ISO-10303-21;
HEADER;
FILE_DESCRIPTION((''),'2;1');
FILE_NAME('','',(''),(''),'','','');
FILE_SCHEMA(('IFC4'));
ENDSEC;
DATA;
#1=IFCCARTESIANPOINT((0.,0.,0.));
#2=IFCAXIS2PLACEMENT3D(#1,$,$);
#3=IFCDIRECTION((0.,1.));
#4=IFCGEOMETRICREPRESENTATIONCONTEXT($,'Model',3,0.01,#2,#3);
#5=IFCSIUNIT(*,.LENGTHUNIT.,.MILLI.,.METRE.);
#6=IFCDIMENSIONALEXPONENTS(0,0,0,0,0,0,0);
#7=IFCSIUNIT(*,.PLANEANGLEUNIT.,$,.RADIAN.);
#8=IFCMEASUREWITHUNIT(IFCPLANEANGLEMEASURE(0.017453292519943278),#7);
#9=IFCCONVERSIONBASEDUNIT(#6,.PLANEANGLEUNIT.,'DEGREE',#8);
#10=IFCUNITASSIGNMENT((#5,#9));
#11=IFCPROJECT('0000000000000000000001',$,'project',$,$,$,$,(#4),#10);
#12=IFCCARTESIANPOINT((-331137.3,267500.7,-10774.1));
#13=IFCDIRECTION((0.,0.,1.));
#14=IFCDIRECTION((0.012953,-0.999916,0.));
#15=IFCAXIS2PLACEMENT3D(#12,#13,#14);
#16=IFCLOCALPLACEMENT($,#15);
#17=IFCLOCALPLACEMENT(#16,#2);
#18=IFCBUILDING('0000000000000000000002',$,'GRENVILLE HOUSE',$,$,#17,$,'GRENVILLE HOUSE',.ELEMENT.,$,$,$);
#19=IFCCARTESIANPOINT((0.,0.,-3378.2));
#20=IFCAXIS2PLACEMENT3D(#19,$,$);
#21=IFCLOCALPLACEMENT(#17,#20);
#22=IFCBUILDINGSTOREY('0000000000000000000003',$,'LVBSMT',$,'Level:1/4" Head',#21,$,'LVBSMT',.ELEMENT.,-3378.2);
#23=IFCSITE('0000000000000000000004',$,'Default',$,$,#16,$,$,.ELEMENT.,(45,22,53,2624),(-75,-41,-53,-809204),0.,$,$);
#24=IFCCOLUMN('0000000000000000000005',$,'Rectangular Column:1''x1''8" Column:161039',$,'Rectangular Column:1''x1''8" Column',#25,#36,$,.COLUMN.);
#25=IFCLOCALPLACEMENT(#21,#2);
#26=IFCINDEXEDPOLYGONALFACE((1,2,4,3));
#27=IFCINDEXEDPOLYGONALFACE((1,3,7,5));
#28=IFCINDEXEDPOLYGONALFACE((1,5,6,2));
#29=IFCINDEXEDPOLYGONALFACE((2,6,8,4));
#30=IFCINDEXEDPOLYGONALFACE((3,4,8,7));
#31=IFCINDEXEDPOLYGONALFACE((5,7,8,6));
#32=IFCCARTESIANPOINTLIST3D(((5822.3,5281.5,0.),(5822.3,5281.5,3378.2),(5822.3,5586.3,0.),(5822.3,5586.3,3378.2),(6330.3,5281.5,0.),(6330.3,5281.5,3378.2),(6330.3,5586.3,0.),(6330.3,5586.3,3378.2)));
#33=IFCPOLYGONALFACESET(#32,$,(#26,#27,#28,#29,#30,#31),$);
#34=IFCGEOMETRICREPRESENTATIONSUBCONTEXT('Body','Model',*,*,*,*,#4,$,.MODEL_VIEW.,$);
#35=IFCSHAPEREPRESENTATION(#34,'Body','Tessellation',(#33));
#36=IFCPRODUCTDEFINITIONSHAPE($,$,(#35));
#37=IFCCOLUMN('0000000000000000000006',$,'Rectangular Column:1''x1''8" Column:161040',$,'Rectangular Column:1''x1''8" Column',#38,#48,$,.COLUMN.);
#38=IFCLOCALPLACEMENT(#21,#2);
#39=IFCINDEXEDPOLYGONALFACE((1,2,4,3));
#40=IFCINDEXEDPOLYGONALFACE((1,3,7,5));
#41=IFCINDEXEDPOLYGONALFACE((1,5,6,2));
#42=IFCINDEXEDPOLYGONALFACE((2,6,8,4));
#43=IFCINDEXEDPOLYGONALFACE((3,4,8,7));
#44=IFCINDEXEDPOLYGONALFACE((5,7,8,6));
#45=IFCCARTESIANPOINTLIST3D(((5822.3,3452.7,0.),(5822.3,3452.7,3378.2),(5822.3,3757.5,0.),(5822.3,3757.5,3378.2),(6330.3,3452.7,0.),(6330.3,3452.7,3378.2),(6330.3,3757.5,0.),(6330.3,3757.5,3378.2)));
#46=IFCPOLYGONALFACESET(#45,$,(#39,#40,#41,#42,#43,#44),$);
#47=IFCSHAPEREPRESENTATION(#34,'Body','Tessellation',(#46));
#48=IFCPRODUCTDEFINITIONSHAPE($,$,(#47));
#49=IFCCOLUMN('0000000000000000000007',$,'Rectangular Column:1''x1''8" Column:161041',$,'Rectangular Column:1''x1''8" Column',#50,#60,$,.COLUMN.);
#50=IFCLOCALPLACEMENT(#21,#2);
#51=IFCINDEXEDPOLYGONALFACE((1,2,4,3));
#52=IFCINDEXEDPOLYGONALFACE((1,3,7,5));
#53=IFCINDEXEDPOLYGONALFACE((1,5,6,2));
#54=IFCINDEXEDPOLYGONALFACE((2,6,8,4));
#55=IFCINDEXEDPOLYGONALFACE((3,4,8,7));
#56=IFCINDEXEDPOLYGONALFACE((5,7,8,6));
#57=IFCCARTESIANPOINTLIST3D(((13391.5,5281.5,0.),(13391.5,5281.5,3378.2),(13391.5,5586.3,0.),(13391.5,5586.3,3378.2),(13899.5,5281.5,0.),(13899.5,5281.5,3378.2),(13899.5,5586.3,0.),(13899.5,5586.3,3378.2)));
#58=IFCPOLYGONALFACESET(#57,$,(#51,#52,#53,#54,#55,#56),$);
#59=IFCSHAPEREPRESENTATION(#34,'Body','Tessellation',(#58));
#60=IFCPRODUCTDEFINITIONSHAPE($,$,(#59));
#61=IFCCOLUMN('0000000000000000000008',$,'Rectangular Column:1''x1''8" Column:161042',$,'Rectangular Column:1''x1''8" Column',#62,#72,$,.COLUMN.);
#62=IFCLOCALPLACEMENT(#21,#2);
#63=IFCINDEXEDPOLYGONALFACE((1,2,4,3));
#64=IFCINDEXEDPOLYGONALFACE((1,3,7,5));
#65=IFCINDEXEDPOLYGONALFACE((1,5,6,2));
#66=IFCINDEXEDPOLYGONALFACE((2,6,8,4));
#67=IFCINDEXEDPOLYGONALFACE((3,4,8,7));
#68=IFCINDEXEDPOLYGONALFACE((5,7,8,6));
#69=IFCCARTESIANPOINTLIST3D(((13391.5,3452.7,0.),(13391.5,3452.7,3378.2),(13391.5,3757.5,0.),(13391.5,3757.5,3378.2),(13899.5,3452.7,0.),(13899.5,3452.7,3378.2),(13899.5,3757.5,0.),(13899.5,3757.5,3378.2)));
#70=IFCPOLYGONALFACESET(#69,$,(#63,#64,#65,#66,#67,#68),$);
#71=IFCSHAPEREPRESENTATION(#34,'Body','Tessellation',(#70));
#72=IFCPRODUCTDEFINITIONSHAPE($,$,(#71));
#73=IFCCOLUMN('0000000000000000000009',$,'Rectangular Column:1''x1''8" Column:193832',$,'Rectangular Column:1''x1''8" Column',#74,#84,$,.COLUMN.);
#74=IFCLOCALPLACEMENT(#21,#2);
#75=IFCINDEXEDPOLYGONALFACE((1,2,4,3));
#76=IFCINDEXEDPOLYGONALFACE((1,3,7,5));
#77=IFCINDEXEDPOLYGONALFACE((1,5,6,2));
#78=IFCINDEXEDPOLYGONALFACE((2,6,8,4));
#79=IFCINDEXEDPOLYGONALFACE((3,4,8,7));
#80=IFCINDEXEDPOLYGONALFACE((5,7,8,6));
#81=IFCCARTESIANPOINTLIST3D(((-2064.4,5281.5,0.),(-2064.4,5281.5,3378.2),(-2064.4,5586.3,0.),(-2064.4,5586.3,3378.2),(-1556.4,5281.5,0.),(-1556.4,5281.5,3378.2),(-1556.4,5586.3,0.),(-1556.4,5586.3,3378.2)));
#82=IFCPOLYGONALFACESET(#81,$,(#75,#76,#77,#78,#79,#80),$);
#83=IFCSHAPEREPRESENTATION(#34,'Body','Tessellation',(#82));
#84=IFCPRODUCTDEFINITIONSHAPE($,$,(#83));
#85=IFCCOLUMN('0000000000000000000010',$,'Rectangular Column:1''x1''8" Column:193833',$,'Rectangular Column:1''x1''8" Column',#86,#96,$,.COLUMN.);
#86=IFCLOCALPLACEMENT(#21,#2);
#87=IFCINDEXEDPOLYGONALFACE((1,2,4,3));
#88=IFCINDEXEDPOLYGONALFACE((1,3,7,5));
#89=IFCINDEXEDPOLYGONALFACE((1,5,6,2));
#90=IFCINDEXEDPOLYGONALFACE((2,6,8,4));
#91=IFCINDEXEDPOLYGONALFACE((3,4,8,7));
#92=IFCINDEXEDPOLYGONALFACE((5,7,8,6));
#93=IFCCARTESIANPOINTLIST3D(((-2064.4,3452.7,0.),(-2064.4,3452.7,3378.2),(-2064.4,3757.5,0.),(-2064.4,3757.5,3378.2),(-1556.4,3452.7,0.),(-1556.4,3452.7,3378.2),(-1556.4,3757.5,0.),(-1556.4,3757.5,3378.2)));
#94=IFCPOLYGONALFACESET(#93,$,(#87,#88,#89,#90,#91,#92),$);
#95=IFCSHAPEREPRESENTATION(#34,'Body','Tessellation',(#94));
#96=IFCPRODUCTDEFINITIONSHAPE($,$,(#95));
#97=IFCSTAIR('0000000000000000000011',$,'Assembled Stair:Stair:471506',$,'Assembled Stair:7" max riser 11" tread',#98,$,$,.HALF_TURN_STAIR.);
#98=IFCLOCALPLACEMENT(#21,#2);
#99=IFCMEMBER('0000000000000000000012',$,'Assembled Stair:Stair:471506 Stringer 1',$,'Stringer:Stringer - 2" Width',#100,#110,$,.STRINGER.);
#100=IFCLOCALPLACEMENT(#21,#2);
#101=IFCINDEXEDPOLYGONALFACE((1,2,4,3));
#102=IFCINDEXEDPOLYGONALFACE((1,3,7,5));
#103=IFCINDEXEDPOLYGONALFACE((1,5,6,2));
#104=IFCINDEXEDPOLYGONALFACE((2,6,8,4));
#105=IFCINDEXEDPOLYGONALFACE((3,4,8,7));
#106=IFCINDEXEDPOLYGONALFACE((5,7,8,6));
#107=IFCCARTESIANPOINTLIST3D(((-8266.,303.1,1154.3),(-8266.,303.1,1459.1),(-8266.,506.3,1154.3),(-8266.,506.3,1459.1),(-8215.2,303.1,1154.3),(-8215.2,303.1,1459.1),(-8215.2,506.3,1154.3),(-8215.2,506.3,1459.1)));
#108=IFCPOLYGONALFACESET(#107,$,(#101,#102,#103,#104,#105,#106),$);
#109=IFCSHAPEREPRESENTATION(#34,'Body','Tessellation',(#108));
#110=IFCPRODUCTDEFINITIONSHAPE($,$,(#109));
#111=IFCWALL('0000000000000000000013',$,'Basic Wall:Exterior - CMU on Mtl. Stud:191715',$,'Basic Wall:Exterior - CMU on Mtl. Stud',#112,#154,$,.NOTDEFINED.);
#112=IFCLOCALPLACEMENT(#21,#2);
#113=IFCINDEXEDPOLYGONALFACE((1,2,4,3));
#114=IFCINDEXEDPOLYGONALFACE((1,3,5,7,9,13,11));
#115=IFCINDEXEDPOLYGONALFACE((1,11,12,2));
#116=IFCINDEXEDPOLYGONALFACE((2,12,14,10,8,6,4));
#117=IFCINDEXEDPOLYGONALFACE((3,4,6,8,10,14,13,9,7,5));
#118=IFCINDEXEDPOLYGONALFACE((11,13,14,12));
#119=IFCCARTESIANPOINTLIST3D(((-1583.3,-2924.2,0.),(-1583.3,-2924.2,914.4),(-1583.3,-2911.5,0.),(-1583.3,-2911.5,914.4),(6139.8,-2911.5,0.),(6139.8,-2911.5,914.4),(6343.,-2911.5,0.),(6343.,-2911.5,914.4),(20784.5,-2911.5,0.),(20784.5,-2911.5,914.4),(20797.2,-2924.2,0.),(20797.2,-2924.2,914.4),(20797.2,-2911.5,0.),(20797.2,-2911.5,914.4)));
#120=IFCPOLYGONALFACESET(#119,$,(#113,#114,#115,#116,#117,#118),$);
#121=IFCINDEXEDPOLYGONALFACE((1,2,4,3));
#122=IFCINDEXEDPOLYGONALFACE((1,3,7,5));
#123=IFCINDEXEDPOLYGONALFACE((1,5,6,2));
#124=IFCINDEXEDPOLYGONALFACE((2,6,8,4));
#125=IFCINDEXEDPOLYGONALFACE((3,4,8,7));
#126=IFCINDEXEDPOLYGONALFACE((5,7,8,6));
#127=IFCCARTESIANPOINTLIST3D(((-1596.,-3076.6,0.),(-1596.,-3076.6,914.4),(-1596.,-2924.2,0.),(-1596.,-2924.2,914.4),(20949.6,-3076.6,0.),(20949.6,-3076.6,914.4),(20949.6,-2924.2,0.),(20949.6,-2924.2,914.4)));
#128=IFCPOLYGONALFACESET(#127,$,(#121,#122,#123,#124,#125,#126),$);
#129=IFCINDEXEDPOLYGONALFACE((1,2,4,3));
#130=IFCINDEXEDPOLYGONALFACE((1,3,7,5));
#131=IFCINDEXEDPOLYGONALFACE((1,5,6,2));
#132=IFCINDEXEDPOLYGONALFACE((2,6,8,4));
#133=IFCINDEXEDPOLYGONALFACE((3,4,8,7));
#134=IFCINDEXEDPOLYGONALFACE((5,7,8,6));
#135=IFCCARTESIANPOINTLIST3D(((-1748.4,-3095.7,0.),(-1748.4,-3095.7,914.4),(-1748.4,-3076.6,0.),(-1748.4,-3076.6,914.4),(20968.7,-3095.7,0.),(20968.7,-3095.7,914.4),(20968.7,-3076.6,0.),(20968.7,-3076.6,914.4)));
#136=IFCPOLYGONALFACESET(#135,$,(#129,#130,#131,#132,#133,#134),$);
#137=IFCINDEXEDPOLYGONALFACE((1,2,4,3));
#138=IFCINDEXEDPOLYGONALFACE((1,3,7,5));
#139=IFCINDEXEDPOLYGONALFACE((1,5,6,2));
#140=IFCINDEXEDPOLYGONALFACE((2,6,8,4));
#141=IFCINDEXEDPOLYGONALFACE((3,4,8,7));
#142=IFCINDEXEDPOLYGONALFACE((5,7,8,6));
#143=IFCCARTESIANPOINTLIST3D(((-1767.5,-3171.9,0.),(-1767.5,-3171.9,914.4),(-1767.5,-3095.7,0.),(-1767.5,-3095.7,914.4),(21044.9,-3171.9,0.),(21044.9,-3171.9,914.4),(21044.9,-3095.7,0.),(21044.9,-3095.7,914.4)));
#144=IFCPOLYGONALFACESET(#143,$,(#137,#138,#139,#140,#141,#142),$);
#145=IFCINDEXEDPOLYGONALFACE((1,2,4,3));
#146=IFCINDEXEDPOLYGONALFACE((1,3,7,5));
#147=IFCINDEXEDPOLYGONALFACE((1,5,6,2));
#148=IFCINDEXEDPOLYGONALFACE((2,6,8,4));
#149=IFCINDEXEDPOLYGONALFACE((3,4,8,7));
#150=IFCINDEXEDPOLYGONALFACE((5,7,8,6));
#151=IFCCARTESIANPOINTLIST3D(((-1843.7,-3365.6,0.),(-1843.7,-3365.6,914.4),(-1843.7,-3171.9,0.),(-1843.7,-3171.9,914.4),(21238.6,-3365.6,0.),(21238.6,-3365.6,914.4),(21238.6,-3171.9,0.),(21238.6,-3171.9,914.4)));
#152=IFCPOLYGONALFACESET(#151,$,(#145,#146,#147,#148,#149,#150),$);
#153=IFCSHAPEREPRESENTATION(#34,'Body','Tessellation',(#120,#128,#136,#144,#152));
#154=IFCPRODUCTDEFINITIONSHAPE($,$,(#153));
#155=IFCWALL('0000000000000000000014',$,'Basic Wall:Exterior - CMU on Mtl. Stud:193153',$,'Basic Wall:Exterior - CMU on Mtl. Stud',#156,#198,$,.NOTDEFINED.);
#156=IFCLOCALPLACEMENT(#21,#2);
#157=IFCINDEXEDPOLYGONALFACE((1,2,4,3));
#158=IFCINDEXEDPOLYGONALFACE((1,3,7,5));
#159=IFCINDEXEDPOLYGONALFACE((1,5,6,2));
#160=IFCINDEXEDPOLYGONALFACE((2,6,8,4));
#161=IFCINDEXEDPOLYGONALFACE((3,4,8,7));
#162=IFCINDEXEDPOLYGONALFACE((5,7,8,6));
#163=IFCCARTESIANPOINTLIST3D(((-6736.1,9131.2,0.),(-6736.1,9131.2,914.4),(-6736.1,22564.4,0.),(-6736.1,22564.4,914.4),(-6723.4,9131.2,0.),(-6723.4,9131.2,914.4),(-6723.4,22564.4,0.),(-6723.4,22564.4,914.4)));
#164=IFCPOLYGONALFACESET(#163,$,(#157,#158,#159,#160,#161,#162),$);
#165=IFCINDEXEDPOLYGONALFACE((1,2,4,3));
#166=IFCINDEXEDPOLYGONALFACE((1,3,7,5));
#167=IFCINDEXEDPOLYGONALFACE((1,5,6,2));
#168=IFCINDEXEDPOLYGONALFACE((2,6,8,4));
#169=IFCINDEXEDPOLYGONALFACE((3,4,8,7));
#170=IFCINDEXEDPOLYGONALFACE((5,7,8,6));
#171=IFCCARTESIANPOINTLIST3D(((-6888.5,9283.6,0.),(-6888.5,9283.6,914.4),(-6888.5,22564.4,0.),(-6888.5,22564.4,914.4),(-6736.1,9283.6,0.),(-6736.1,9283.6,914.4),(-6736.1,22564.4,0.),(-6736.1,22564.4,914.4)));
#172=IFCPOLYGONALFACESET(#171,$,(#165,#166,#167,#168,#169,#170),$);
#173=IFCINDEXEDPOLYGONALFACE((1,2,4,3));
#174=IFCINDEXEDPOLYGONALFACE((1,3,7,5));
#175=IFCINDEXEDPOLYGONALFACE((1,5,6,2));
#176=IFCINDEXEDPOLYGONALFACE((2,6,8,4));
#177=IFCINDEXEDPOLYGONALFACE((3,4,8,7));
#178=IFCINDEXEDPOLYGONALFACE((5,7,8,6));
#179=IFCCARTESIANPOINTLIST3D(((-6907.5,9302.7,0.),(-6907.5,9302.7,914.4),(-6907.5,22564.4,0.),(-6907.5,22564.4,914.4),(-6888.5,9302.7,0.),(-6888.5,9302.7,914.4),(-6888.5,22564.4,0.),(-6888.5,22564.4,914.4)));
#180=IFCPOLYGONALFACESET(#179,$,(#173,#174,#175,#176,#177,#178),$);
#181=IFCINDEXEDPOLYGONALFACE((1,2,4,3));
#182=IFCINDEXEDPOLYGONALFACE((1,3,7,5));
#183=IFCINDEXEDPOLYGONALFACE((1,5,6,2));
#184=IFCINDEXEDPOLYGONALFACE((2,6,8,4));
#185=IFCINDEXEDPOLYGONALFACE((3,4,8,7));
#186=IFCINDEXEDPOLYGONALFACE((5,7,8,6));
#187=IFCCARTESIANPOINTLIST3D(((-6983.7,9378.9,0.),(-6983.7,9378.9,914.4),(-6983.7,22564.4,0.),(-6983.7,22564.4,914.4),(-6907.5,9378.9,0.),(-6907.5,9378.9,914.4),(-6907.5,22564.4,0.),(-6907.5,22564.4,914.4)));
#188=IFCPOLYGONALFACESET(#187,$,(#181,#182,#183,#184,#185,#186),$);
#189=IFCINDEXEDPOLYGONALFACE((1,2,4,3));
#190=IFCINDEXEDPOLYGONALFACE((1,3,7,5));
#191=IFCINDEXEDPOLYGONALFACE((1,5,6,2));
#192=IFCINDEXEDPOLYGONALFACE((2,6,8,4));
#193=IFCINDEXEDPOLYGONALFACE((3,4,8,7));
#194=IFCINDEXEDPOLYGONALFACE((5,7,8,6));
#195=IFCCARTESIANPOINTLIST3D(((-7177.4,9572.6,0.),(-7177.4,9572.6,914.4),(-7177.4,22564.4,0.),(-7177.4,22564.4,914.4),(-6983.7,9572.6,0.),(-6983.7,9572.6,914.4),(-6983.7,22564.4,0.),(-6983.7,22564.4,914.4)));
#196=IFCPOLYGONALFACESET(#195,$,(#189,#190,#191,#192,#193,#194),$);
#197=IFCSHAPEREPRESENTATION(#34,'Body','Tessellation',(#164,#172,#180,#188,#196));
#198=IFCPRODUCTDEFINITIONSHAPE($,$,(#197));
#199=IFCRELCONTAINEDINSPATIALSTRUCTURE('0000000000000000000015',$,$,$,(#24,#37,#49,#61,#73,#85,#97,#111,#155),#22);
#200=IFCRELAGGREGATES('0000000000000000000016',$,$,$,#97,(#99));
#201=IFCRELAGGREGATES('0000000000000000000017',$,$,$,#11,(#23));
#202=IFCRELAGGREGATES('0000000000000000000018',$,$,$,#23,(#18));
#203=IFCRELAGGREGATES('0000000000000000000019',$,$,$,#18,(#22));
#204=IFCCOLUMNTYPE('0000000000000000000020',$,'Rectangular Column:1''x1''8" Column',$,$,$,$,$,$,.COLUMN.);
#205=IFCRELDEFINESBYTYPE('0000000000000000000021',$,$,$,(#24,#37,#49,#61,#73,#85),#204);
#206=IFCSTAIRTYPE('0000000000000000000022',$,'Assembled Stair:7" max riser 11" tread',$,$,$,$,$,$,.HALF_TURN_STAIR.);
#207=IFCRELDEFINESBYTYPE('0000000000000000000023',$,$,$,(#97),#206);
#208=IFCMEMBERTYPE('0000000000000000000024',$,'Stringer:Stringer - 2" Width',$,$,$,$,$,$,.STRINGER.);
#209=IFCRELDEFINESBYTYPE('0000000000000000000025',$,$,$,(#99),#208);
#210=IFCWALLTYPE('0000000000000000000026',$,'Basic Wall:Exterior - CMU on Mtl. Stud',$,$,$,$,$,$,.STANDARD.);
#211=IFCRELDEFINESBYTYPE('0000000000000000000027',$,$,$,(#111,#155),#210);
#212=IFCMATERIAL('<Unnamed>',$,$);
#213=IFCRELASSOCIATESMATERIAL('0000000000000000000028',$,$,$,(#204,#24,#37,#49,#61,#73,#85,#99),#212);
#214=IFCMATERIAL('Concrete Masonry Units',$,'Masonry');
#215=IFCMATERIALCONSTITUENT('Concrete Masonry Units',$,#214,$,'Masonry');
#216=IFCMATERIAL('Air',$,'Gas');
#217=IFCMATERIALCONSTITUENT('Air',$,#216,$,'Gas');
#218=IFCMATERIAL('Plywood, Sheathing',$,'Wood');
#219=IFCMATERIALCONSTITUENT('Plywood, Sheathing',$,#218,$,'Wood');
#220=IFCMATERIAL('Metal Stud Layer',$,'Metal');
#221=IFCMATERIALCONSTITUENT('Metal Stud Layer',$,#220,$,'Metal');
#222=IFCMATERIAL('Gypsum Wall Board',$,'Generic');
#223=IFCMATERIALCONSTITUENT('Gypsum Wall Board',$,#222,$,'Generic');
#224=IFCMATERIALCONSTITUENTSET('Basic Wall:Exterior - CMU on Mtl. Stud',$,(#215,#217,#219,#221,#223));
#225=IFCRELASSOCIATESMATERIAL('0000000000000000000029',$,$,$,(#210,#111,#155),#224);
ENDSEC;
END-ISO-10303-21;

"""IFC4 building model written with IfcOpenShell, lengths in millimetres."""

from ifc_helpers import new_model, entity, si_unit, converted_unit, direction, frame, origin, place, context, subcontext, project, spatial, indexed_curve, outline, extrude, source, transform, mapped, material, constituent, constituent_set, type_object, type_shapes, element, aggregate, save


model = new_model("IFC4")

# Units and contexts
model_context = context("Model", 3, precision=0.01, world=origin(), true_north=direction((0.0, 1.0)))
body_context = subcontext(model_context, "Body", "Model", "MODEL_VIEW")
ifc_project = project(units=[si_unit("LENGTHUNIT", "METRE", prefix="MILLI"), converted_unit("PLANEANGLEUNIT", "DEGREE", entity("IfcPlaneAngleMeasure", 0.017453292519943278), si_unit("PLANEANGLEUNIT", "RADIAN"), dimensions=[0, 0, 0, 0, 0, 0, 0])], contexts=[model_context])

# Site, building, storey
site_placement = place(None, frame((-331137.3, 267500.7, -10774.1), z_axis=(0.0, 0.0, 1.0), x_axis=(0.012953, -0.999916, 0.0)))
site = spatial("IfcSite", under=ifc_project, at=site_placement, Name="Default", CompositionType="ELEMENT", RefLatitude=(45, 22, 53, 2624), RefLongitude=(-75, -41, -53, -809204), RefElevation=0.0)
building_placement = place(site_placement, origin())
building = spatial("IfcBuilding", under=site, at=building_placement, Name="GRENVILLE HOUSE", LongName="GRENVILLE HOUSE", CompositionType="ELEMENT")
storey_placement = place(building_placement, frame((0.0, 0.0, -3378.2)))
storey = spatial("IfcBuildingStorey", under=building, at=storey_placement, Name="LVBSMT", ObjectType="Level:1/4\" Head", LongName="LVBSMT", CompositionType="ELEMENT", Elevation=-3378.2)

# Columns
ifc_material_1 = material(Name="<Unnamed>")
column_type_1 = type_object("IfcColumnType", Name="Rectangular Column:1'x1'8\" Column", PredefinedType="COLUMN", material=ifc_material_1)
shared_shape_1 = source(origin(), body_context, "Body", "SweptSolid", [
    extrude(outline(indexed_curve([(-254.0, -152.4), (254.0, -152.4), (254.0, 152.4), (-254.0, 152.4), (-254.0, -152.4)], self_intersect=False)), frame((0.0, 0.0, -3378.2), z_axis=(0.0, 0.0, 1.0), x_axis=(-1.0, 0.0, 0.0)), (0.0, 0.0, 1.0), 3378.2),
])
type_shapes(column_type_1, [shared_shape_1])
for number, where, name in (
    (1, (6076.3, 5433.9, 3378.2), "Rectangular Column:1'x1'8\" Column:161039"),
    (2, (6076.3, 3605.1, 3378.2), "Rectangular Column:1'x1'8\" Column:161040"),
    (3, (13645.5, 5433.9, 3378.2), "Rectangular Column:1'x1'8\" Column:161041"),
    (4, (13645.5, 3605.1, 3378.2), "Rectangular Column:1'x1'8\" Column:161042"),
    (5, (-1810.4, 5433.9, 3378.2), "Rectangular Column:1'x1'8\" Column:193832"),
    (6, (-1810.4, 3605.1, 3378.2), "Rectangular Column:1'x1'8\" Column:193833"),
):
    element("IfcColumn", number, at=place(storey_placement, frame(where)), inside=storey, type_object=column_type_1, material=ifc_material_1, Name=name, ObjectType="Rectangular Column:1'x1'8\" Column", PredefinedType="COLUMN", context=body_context, shape_type="MappedRepresentation", body=[
        mapped(shared_shape_1, transform((0.0, 0.0, 0.0), scale=1.0)),
    ])
ifc_material_2 = material(Name="Concrete Masonry Units", Category="Masonry")

# Stair, member
stair_type = type_object("IfcStairType", Name="Assembled Stair:7\" max riser 11\" tread", PredefinedType="HALF_TURN_STAIR")
stair_placement = place(storey_placement, origin())
stair = element("IfcStair", 7, at=stair_placement, inside=storey, type_object=stair_type, Name="Assembled Stair:Stair:471506", ObjectType="Assembled Stair:7\" max riser 11\" tread", PredefinedType="HALF_TURN_STAIR")
member_type = type_object("IfcMemberType", Name="Stringer:Stringer - 2\" Width", PredefinedType="STRINGER")
member_placement = place(stair_placement, frame((-8266.0, 303.1, 1154.3)))
member = element("IfcMember", 8, at=member_placement, type_object=member_type, material=ifc_material_1, Name="Assembled Stair:Stair:471506 Stringer 1", ObjectType="Stringer:Stringer - 2\" Width", PredefinedType="STRINGER", context=body_context, shape_type="SweptSolid", body=[
    extrude(outline(indexed_curve([(-101.6, -25.4), (101.6, -25.4), (101.6, 25.4), (-101.6, 25.4), (-101.6, -25.4)], self_intersect=False)), frame((25.4, 101.6, 0.0), z_axis=(0.0, 0.0, 1.0), x_axis=(0.0, 1.0, 0.0)), (0.0, 0.0, 1.0), 304.8),
])

# Walls
ifc_constituent_1 = constituent(ifc_material_2, Name="Concrete Masonry Units", Category="Masonry")
ifc_material_3 = material(Name="Air", Category="Gas")
ifc_constituent_2 = constituent(ifc_material_3, Name="Air", Category="Gas")
ifc_material_4 = material(Name="Plywood, Sheathing", Category="Wood")
ifc_constituent_3 = constituent(ifc_material_4, Name="Plywood, Sheathing", Category="Wood")
ifc_material_5 = material(Name="Metal Stud Layer", Category="Metal")
ifc_constituent_4 = constituent(ifc_material_5, Name="Metal Stud Layer", Category="Metal")
ifc_material_6 = material(Name="Gypsum Wall Board", Category="Generic")
ifc_constituent_5 = constituent(ifc_material_6, Name="Gypsum Wall Board", Category="Generic")
ifc_constituent_set = constituent_set(constituents=[ifc_constituent_1, ifc_constituent_2, ifc_constituent_3, ifc_constituent_4, ifc_constituent_5], Name="Basic Wall:Exterior - CMU on Mtl. Stud")
wall_type_1 = type_object("IfcWallType", Name="Basic Wall:Exterior - CMU on Mtl. Stud", PredefinedType="STANDARD", material=ifc_constituent_set)
wall_1_placement = place(storey_placement, frame((-1583.3, -3138.6, 0.0)))
element("IfcWall", 9, at=wall_1_placement, inside=storey, type_object=wall_type_1, material=ifc_constituent_set, Name="Basic Wall:Exterior - CMU on Mtl. Stud:191715", ObjectType="Basic Wall:Exterior - CMU on Mtl. Stud", PredefinedType="NOTDEFINED", context=body_context, shape_type="SweptSolid", body=[
    extrude(outline(indexed_curve([(-10542.4, -3.6), (3899.1, -3.6), (4102.3, -3.6), (11825.5, -3.6), (11825.5, 9.1), (-10555.1, 9.1), (-10555.1, -3.6), (-10542.4, -3.6)], self_intersect=False)), frame((11825.5, 223.4, 0.0), z_axis=(0.0, 0.0, 1.0), x_axis=(-1.0, 0.0, 0.0)), (0.0, 0.0, 1.0), 914.4),
    extrude(outline(indexed_curve([(-11272.8, -76.2), (11272.8, -76.2), (11272.8, 76.2), (-11272.8, 76.2), (-11272.8, -76.2)], self_intersect=False)), frame((11260.1, 138.1, 0.0)), (0.0, 0.0, 1.0), 914.4),
    extrude(outline(indexed_curve([(-11358.6, -9.5), (11358.6, -9.5), (11358.6, 9.5), (-11358.6, 9.5), (-11358.6, -9.5)], self_intersect=False)), frame((11193.5, 52.4, 0.0)), (0.0, 0.0, 1.0), 914.4),
    extrude(outline(indexed_curve([(-11406.2, -38.1), (11406.2, -38.1), (11406.2, 38.1), (-11406.2, 38.1), (-11406.2, -38.1)], self_intersect=False)), frame((11222.0, 4.8, 0.0)), (0.0, 0.0, 1.0), 914.4),
    extrude(outline(indexed_curve([(-96.8, -11541.1), (96.8, -11541.1), (96.8, 11541.1), (-96.8, 11541.1), (-96.8, -11541.1)], self_intersect=False)), frame((11280.8, -130.2, 0.0), z_axis=(0.0, 0.0, 1.0), x_axis=(0.0, 1.0, 0.0)), (0.0, 0.0, 1.0), 914.4),
])
wall_2_placement = place(storey_placement, frame((-6950.4, 9572.6, 0.0), z_axis=(0.0, 0.0, 1.0), x_axis=(0.0, 1.0, 0.0)))
element("IfcWall", 10, at=wall_2_placement, inside=storey, type_object=wall_type_1, material=ifc_constituent_set, Name="Basic Wall:Exterior - CMU on Mtl. Stud:193153", ObjectType="Basic Wall:Exterior - CMU on Mtl. Stud", PredefinedType="NOTDEFINED", context=body_context, shape_type="SweptSolid", body=[
    extrude(outline(indexed_curve([(-6.4, -6716.6), (6.3, -6716.6), (6.4, 6716.6), (-6.3, 6716.6), (-6.4, -6716.6)], self_intersect=False)), frame((6275.3, -220.7, 0.0), z_axis=(0.0, 0.0, 1.0), x_axis=(0.0, 1.0, 0.0)), (0.0, 0.0, 1.0), 914.4),
    extrude(outline(indexed_curve([(-6640.4, -76.2), (6640.4, -76.2), (6640.4, 76.2), (-6640.4, 76.2), (-6640.4, -76.2)], self_intersect=False)), frame((6351.5, -138.1, 0.0)), (0.0, 0.0, 1.0), 914.4),
    extrude(outline(indexed_curve([(-6630.9, -9.5), (6630.9, -9.5), (6630.9, 9.5), (-6630.9, 9.5), (-6630.9, -9.5)], self_intersect=False)), frame((6361.0, -52.4, 0.0)), (0.0, 0.0, 1.0), 914.4),
    extrude(outline(indexed_curve([(-6592.8, -38.1), (6592.8, -38.1), (6592.8, 38.1), (-6592.8, 38.1), (-6592.8, -38.1)], self_intersect=False)), frame((6399.1, -4.8, 0.0)), (0.0, 0.0, 1.0), 914.4),
    extrude(outline(indexed_curve([(-96.8, -6495.9), (96.8, -6495.9), (96.8, 6495.9), (-96.8, 6495.9), (-96.8, -6495.9)], self_intersect=False)), frame((6495.9, 130.2, 0.0), z_axis=(0.0, 0.0, 1.0), x_axis=(0.0, -1.0, 0.0)), (0.0, 0.0, 1.0), 914.4),
])

aggregate(stair, [member])

save(model, "model.ifc")
